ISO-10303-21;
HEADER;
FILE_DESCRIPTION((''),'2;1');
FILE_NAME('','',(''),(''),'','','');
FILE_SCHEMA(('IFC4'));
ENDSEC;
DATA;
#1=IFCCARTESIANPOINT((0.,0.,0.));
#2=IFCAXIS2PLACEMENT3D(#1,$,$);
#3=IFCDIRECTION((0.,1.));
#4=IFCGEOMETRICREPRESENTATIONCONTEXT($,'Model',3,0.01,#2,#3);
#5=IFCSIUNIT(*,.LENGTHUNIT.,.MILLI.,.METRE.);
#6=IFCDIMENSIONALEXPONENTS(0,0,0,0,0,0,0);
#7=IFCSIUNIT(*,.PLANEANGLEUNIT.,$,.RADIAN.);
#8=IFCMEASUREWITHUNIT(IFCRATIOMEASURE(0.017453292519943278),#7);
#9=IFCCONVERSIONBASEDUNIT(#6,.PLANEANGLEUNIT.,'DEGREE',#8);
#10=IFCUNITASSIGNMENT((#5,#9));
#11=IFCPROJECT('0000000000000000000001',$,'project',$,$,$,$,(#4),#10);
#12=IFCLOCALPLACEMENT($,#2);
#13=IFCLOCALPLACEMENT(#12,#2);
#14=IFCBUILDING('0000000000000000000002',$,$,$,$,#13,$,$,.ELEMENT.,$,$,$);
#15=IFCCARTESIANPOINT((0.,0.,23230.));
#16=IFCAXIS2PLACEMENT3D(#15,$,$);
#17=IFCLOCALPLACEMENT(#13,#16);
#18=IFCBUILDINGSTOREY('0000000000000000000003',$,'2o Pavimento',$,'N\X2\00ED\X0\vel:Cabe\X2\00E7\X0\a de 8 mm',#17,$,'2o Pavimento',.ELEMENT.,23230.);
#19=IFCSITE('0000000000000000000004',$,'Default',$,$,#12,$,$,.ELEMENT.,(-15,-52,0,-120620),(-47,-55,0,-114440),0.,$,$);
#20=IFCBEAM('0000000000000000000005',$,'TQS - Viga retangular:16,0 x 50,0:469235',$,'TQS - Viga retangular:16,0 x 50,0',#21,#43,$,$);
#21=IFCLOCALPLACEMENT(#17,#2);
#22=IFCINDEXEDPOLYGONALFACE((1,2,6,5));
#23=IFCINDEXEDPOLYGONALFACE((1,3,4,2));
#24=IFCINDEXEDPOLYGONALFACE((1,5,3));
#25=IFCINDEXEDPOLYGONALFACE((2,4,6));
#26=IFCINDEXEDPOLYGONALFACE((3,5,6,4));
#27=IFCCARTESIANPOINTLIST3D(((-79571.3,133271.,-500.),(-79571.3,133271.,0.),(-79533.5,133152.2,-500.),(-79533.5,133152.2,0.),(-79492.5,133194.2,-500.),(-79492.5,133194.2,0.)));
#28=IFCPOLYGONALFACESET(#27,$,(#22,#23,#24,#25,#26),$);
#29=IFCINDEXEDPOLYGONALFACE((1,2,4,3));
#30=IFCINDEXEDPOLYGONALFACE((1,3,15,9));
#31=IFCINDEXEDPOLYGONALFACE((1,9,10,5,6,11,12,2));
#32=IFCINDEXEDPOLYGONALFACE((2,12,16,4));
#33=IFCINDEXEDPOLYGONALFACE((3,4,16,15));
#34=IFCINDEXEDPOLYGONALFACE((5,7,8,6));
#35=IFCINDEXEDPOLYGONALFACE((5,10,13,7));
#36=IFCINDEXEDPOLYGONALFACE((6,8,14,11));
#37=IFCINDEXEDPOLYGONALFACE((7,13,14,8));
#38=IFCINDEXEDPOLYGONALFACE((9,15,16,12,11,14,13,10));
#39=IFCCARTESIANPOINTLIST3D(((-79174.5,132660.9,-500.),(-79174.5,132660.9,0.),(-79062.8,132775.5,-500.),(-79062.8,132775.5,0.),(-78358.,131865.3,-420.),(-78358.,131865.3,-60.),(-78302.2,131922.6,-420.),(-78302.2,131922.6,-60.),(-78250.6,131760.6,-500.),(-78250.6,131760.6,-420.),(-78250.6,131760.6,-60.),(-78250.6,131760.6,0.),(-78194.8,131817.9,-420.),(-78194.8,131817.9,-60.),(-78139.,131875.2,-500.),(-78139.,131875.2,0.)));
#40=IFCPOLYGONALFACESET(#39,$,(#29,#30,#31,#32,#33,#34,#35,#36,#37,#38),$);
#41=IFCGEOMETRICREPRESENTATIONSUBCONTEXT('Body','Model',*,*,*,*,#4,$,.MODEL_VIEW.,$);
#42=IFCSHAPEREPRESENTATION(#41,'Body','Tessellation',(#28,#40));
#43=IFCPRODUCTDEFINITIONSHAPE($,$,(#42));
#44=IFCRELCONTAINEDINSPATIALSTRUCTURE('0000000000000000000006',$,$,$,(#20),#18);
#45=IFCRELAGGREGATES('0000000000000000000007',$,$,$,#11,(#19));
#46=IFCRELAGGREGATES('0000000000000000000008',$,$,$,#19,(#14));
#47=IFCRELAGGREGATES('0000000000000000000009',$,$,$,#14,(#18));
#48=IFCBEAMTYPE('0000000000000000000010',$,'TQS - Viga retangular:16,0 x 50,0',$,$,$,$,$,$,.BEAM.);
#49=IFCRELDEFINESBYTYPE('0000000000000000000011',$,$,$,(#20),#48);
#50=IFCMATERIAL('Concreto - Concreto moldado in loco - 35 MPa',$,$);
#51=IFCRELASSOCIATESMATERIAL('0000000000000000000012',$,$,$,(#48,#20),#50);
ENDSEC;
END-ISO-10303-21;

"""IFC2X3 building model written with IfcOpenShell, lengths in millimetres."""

from ifc_helpers import new_model, entity, si_unit, converted_unit, direction, frame, frame_2d, origin, place, context, subcontext, project, spatial, polyline, rectangle, extrude, boolean, clip, halfspace, bounded_halfspace, source, transform, mapped, material, type_object, type_shapes, element, save


model = new_model("IFC2X3")

# Units and contexts
model_context = context("Model", 3, precision=0.01, world=origin(), true_north=direction((0.0, 1.0)))
body_context = subcontext(model_context, "Body", "Model", "MODEL_VIEW")
ifc_project = project(units=[si_unit("LENGTHUNIT", "METRE", prefix="MILLI"), converted_unit("PLANEANGLEUNIT", "DEGREE", entity("IfcRatioMeasure", 0.017453292519943278), si_unit("PLANEANGLEUNIT", "RADIAN"), dimensions=[0, 0, 0, 0, 0, 0, 0])], contexts=[model_context])

# Site, building, storey
site_placement = place(None, origin())
site = spatial("IfcSite", under=ifc_project, at=site_placement, Name="Default", CompositionType="ELEMENT", RefLatitude=(-15, -52, 0, -120620), RefLongitude=(-47, -55, 0, -114440), RefElevation=0.0)
building_placement = place(site_placement, origin())
building = spatial("IfcBuilding", under=site, at=building_placement, CompositionType="ELEMENT")
storey_placement = place(building_placement, frame((0.0, 0.0, 23230.0)))
storey = spatial("IfcBuildingStorey", under=building, at=storey_placement, Name="2o Pavimento", ObjectType="Nível:Cabeça de 8 mm", LongName="2o Pavimento", CompositionType="ELEMENT", Elevation=23230.0)

# Shared definitions
ifc_material = material(Name="Concreto - Concreto moldado in loco - 35 MPa")

# Beam
beam_type = type_object("IfcBeamType", Name="TQS - Viga retangular:16,0 x 50,0", PredefinedType="BEAM", material=ifc_material)
shared_shape_1 = source(origin(), body_context, "Body", "SweptSolid", [
    clip(extrude(rectangle(XDim=500.0, YDim=58.7, at=frame_2d((0.0, 0.0), x_axis=(1.0, 0.0))), frame((-79513.0, 133173.2, 22980.0), z_axis=(-0.71618, 0.697915, 0.0), x_axis=(0.0, 0.0, 1.0)), (0.0, 0.0, 1.0), 110.0), halfspace(frame((-79468.1, 132947.1, 23230.0), z_axis=(-0.952834, -0.303493, 0.0), x_axis=(0.303493, -0.952834, 0.0)), False)),
    boolean("DIFFERENCE", clip(extrude(rectangle(XDim=500.0, YDim=160.0, at=frame_2d((0.0, 0.0), x_axis=(0.0, 1.0))), frame((-78194.8, 131817.9, 22980.0), z_axis=(-0.71618, 0.697915, 0.0), x_axis=(0.697915, 0.71618, 0.0)), (0.0, 0.0, 1.0), 1290.0), bounded_halfspace(frame((-78302.2, 131922.6, 22810.0), z_axis=(0.71618, -0.697915, 0.0), x_axis=(-0.697915, -0.71618, 0.0)), False, frame((-78194.8, 131817.9, 22980.0), z_axis=(-0.71618, 0.697915, 0.0), x_axis=(0.697915, 0.71618, 0.0)), polyline([(0.0, 170.0), (0.0, -190.0), (-80.0, -190.0), (-80.0, -90.0), (-80.0, 170.0), (0.0, 170.0)]))), extrude(rectangle(XDim=360.0, YDim=80.0, at=frame_2d((0.0, 0.0), x_axis=(0.0, 1.0))), frame((-78222.7, 131789.3, 22990.0), z_axis=(0.71618, -0.697915, 0.0), x_axis=(0.697915, 0.71618, 0.0)), (0.0, 0.0, -1.0), 150.0)),
])
type_shapes(beam_type, [shared_shape_1])
beam_placement = place(storey_placement, frame((0.0, 0.0, -23230.0)))
element("IfcBeam", 1, at=beam_placement, inside=storey, type_object=beam_type, material=ifc_material, Name="TQS - Viga retangular:16,0 x 50,0:469235", ObjectType="TQS - Viga retangular:16,0 x 50,0", context=body_context, shape_type="MappedRepresentation", body=[
    mapped(shared_shape_1, transform((0.0, 0.0, 0.0), scale=1.0)),
])

save(model, "model.ifc")
